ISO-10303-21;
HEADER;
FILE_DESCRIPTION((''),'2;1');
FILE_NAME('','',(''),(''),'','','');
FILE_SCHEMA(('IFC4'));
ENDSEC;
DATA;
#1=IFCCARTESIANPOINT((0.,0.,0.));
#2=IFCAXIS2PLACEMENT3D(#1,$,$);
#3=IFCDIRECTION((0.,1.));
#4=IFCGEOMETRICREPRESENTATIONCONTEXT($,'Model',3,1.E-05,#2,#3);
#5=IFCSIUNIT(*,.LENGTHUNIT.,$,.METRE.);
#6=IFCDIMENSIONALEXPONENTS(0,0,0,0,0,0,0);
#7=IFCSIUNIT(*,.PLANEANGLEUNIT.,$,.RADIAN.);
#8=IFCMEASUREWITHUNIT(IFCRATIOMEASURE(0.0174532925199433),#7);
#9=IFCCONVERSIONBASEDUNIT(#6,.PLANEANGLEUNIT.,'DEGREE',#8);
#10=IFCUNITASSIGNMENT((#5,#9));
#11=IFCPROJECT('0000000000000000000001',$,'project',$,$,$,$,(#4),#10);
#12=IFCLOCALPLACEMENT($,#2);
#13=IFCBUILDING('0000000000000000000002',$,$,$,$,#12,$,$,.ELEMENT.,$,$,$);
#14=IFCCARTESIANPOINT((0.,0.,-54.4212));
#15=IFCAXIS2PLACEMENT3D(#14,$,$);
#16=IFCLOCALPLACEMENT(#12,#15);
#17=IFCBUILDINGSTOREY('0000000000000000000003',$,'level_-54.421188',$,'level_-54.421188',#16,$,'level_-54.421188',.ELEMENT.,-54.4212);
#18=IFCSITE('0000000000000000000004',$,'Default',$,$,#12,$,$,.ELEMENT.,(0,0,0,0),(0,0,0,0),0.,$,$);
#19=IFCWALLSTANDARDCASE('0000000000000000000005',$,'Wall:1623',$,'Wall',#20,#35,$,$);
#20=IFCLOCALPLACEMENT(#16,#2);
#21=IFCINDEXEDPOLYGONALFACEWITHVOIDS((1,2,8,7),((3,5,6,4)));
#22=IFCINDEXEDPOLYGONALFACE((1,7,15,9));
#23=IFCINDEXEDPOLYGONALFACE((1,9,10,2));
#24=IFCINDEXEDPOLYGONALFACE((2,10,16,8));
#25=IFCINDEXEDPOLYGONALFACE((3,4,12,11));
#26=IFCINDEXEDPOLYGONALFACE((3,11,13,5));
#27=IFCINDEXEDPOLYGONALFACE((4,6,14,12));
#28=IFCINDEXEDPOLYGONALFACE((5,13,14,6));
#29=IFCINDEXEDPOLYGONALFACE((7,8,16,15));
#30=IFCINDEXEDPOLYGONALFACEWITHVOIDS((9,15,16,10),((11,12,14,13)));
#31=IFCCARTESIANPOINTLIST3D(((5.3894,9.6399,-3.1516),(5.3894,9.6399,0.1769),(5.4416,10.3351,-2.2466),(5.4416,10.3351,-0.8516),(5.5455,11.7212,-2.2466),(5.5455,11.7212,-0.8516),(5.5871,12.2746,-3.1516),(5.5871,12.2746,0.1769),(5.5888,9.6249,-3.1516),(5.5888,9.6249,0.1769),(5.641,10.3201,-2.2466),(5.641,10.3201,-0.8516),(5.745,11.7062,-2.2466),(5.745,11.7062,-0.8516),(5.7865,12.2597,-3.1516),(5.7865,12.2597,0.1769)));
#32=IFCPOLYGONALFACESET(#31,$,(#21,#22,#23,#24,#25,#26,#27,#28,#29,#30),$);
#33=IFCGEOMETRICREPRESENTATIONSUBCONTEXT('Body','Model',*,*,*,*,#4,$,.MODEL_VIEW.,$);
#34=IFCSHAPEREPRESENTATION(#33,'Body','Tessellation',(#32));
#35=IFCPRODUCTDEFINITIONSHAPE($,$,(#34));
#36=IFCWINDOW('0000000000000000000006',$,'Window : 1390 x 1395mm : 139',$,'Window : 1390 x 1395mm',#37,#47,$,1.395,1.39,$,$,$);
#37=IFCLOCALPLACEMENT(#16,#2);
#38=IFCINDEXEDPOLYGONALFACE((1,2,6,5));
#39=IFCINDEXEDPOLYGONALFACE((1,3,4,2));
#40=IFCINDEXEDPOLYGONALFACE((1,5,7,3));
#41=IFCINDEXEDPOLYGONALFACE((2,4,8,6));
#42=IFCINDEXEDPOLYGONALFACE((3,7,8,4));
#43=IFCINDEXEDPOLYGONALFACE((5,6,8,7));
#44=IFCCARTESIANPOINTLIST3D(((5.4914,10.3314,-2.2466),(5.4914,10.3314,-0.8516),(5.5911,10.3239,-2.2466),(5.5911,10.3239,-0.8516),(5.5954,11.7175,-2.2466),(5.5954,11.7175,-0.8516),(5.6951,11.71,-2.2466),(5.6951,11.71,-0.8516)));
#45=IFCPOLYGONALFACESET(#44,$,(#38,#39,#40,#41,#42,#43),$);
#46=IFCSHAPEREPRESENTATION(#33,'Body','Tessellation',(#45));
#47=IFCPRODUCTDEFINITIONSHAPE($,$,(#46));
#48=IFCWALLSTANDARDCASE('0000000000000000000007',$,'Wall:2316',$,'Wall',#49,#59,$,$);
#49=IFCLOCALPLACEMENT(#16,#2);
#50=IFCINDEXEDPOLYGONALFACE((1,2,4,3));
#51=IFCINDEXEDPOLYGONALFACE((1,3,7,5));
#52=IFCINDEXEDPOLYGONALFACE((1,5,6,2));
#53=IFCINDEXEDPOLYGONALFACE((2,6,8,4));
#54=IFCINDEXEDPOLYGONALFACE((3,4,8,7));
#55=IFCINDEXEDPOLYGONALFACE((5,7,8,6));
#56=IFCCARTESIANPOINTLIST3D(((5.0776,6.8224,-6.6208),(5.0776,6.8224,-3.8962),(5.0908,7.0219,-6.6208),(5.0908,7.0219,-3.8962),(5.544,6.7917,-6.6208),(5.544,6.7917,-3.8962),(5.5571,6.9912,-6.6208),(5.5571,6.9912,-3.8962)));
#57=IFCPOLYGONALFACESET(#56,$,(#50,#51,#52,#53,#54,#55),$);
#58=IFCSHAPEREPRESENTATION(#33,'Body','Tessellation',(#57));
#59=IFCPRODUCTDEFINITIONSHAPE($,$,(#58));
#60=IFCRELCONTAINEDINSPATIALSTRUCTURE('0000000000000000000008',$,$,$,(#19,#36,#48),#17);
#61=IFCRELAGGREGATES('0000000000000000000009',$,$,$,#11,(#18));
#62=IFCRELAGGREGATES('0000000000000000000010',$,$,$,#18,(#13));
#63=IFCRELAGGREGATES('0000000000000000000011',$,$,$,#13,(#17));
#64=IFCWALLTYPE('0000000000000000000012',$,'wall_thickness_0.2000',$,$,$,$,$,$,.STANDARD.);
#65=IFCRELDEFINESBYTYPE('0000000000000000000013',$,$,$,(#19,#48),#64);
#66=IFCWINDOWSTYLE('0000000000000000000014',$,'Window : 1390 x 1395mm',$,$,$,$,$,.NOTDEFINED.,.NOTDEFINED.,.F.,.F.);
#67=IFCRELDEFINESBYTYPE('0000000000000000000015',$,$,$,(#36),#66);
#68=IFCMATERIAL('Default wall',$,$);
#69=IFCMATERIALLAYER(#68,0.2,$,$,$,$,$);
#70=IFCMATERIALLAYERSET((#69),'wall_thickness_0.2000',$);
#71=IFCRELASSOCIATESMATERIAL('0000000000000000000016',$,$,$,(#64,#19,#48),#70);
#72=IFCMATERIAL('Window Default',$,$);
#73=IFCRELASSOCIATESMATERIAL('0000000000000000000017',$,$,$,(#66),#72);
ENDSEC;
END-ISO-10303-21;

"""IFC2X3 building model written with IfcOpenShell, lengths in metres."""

from ifc_helpers import new_model, entity, si_unit, converted_unit, direction, frame, frame_2d, origin, origin_2d_with_axis, place, context, subcontext, project, spatial, polyline, rectangle, outline, extrude, source, transform, mapped, material, layer, layer_set, layer_usage, type_object, type_shapes, element, fill, save


model = new_model("IFC2X3")

# Units and contexts
model_context = context("Model", 3, precision=1e-05, world=origin(), true_north=direction((0.0, 1.0)))
body_context = subcontext(model_context, "Body", "Model", "MODEL_VIEW")
ifc_project = project(units=[si_unit("LENGTHUNIT", "METRE"), converted_unit("PLANEANGLEUNIT", "DEGREE", entity("IfcRatioMeasure", 0.0174532925199433), si_unit("PLANEANGLEUNIT", "RADIAN"), dimensions=[0, 0, 0, 0, 0, 0, 0])], contexts=[model_context])

# Site, building, storey
placement_1 = place(None, origin())
site = spatial("IfcSite", under=ifc_project, at=placement_1, Name="Default", CompositionType="ELEMENT", RefLatitude=(0, 0, 0, 0), RefLongitude=(0, 0, 0, 0), RefElevation=0.0)
building = spatial("IfcBuilding", under=site, at=placement_1, CompositionType="ELEMENT")
storey_placement = place(placement_1, frame((0.0, 0.0, -54.4212)))
storey = spatial("IfcBuildingStorey", under=building, at=storey_placement, Name="level_-54.421188", ObjectType="level_-54.421188", LongName="level_-54.421188", CompositionType="ELEMENT", Elevation=-54.4212)

# Shared definitions
ifc_material_1 = material(Name="Default wall")
ifc_layer = layer(ifc_material_1, 0.2)
ifc_layer_set = layer_set([ifc_layer], Name="wall_thickness_0.2000")
ifc_layer_usage = layer_usage(ifc_layer_set, "AXIS2", "POSITIVE", -0.1)
wall_type = type_object("IfcWallType", Name="wall_thickness_0.2000", PredefinedType="STANDARD", material=ifc_layer_set)
ifc_material_2 = material(Name="Window Default")

# Wall, opening, window
placement_2 = place(placement_1, frame((0.0, 0.0, -57.5728)))
wall_1_placement = place(placement_2, frame((5.6868, 12.2672, 0.0), z_axis=(0.0, 0.0, 1.0), x_axis=(-0.074813, -0.997198, 0.0)))
wall_1 = element("IfcWallStandardCase", 1, at=wall_1_placement, inside=storey, type_object=wall_type, material=ifc_layer_usage, Name="Wall:1623", ObjectType="Wall", context=body_context, shape_type="SweptSolid", body=[
    extrude(outline(polyline([(2.6421, -0.1), (2.6421, 0.1), (0.0, 0.1), (0.0, -0.1), (2.6421, -0.1)])), origin(), (0.0, 0.0, 1.0), 3.3285),
])
opening_1_placement = place(wall_1_placement, frame((0.555, -0.1, 0.905)))
opening_1 = element("IfcOpeningElement", 2, at=opening_1_placement, cuts=wall_1, ObjectType="Opening", context=body_context, shape_type="SweptSolid", body=[
    extrude(rectangle(XDim=1.39, YDim=1.395, at=frame_2d((0.6975, 0.695), x_axis=(0.0, 1.0))), frame((0.0, 0.0, 0.0), z_axis=(0.0, 1.0, 0.0), x_axis=(0.0, 0.0, 1.0)), (0.0, 0.0, 1.0), 0.2),
])
window_style_1 = type_object("IfcWindowStyle", Name="Window : 1390 x 1395mm", ConstructionType="NOTDEFINED", OperationType="NOTDEFINED", ParameterTakesPrecedence=False, Sizeable=False, material=ifc_material_2)
shared_shape_1 = source(origin(), body_context, "Body", "SweptSolid", [
    extrude(rectangle(XDim=0.1, YDim=1.39, at=origin_2d_with_axis()), frame((0.695, 0.1, 0.0), z_axis=(0.0, 0.0, 1.0), x_axis=(0.0, 1.0, 0.0)), (0.0, 0.0, 1.0), 1.395),
])
type_shapes(window_style_1, [shared_shape_1])
window_1_placement = place(opening_1_placement, origin())
window_1 = element("IfcWindow", 3, at=window_1_placement, inside=storey, type_object=window_style_1, Name="Window : 1390 x 1395mm : 139", ObjectType="Window : 1390 x 1395mm", OverallHeight=1.395, OverallWidth=1.39, context=body_context, shape_type="MappedRepresentation", body=[
    mapped(shared_shape_1, transform((0.0, 0.0, 0.0), scale=1.0)),
])
fill(opening_1, window_1)

# Wall
placement_3 = place(placement_1, frame((0.0, 0.0, -61.042)))
wall_2_placement = place(placement_3, frame((5.5506, 6.8915, 0.0), z_axis=(0.0, 0.0, 1.0), x_axis=(-0.997842, 0.065662, 0.0)))
element("IfcWallStandardCase", 4, at=wall_2_placement, inside=storey, type_object=wall_type, material=ifc_layer_usage, Name="Wall:2316", ObjectType="Wall", context=body_context, shape_type="SweptSolid", body=[
    extrude(outline(polyline([(0.4674, -0.1), (0.4674, 0.1), (0.0, 0.1), (0.0, -0.1), (0.4674, -0.1)])), origin(), (0.0, 0.0, 1.0), 2.7247),
])

save(model, "model.ifc")
